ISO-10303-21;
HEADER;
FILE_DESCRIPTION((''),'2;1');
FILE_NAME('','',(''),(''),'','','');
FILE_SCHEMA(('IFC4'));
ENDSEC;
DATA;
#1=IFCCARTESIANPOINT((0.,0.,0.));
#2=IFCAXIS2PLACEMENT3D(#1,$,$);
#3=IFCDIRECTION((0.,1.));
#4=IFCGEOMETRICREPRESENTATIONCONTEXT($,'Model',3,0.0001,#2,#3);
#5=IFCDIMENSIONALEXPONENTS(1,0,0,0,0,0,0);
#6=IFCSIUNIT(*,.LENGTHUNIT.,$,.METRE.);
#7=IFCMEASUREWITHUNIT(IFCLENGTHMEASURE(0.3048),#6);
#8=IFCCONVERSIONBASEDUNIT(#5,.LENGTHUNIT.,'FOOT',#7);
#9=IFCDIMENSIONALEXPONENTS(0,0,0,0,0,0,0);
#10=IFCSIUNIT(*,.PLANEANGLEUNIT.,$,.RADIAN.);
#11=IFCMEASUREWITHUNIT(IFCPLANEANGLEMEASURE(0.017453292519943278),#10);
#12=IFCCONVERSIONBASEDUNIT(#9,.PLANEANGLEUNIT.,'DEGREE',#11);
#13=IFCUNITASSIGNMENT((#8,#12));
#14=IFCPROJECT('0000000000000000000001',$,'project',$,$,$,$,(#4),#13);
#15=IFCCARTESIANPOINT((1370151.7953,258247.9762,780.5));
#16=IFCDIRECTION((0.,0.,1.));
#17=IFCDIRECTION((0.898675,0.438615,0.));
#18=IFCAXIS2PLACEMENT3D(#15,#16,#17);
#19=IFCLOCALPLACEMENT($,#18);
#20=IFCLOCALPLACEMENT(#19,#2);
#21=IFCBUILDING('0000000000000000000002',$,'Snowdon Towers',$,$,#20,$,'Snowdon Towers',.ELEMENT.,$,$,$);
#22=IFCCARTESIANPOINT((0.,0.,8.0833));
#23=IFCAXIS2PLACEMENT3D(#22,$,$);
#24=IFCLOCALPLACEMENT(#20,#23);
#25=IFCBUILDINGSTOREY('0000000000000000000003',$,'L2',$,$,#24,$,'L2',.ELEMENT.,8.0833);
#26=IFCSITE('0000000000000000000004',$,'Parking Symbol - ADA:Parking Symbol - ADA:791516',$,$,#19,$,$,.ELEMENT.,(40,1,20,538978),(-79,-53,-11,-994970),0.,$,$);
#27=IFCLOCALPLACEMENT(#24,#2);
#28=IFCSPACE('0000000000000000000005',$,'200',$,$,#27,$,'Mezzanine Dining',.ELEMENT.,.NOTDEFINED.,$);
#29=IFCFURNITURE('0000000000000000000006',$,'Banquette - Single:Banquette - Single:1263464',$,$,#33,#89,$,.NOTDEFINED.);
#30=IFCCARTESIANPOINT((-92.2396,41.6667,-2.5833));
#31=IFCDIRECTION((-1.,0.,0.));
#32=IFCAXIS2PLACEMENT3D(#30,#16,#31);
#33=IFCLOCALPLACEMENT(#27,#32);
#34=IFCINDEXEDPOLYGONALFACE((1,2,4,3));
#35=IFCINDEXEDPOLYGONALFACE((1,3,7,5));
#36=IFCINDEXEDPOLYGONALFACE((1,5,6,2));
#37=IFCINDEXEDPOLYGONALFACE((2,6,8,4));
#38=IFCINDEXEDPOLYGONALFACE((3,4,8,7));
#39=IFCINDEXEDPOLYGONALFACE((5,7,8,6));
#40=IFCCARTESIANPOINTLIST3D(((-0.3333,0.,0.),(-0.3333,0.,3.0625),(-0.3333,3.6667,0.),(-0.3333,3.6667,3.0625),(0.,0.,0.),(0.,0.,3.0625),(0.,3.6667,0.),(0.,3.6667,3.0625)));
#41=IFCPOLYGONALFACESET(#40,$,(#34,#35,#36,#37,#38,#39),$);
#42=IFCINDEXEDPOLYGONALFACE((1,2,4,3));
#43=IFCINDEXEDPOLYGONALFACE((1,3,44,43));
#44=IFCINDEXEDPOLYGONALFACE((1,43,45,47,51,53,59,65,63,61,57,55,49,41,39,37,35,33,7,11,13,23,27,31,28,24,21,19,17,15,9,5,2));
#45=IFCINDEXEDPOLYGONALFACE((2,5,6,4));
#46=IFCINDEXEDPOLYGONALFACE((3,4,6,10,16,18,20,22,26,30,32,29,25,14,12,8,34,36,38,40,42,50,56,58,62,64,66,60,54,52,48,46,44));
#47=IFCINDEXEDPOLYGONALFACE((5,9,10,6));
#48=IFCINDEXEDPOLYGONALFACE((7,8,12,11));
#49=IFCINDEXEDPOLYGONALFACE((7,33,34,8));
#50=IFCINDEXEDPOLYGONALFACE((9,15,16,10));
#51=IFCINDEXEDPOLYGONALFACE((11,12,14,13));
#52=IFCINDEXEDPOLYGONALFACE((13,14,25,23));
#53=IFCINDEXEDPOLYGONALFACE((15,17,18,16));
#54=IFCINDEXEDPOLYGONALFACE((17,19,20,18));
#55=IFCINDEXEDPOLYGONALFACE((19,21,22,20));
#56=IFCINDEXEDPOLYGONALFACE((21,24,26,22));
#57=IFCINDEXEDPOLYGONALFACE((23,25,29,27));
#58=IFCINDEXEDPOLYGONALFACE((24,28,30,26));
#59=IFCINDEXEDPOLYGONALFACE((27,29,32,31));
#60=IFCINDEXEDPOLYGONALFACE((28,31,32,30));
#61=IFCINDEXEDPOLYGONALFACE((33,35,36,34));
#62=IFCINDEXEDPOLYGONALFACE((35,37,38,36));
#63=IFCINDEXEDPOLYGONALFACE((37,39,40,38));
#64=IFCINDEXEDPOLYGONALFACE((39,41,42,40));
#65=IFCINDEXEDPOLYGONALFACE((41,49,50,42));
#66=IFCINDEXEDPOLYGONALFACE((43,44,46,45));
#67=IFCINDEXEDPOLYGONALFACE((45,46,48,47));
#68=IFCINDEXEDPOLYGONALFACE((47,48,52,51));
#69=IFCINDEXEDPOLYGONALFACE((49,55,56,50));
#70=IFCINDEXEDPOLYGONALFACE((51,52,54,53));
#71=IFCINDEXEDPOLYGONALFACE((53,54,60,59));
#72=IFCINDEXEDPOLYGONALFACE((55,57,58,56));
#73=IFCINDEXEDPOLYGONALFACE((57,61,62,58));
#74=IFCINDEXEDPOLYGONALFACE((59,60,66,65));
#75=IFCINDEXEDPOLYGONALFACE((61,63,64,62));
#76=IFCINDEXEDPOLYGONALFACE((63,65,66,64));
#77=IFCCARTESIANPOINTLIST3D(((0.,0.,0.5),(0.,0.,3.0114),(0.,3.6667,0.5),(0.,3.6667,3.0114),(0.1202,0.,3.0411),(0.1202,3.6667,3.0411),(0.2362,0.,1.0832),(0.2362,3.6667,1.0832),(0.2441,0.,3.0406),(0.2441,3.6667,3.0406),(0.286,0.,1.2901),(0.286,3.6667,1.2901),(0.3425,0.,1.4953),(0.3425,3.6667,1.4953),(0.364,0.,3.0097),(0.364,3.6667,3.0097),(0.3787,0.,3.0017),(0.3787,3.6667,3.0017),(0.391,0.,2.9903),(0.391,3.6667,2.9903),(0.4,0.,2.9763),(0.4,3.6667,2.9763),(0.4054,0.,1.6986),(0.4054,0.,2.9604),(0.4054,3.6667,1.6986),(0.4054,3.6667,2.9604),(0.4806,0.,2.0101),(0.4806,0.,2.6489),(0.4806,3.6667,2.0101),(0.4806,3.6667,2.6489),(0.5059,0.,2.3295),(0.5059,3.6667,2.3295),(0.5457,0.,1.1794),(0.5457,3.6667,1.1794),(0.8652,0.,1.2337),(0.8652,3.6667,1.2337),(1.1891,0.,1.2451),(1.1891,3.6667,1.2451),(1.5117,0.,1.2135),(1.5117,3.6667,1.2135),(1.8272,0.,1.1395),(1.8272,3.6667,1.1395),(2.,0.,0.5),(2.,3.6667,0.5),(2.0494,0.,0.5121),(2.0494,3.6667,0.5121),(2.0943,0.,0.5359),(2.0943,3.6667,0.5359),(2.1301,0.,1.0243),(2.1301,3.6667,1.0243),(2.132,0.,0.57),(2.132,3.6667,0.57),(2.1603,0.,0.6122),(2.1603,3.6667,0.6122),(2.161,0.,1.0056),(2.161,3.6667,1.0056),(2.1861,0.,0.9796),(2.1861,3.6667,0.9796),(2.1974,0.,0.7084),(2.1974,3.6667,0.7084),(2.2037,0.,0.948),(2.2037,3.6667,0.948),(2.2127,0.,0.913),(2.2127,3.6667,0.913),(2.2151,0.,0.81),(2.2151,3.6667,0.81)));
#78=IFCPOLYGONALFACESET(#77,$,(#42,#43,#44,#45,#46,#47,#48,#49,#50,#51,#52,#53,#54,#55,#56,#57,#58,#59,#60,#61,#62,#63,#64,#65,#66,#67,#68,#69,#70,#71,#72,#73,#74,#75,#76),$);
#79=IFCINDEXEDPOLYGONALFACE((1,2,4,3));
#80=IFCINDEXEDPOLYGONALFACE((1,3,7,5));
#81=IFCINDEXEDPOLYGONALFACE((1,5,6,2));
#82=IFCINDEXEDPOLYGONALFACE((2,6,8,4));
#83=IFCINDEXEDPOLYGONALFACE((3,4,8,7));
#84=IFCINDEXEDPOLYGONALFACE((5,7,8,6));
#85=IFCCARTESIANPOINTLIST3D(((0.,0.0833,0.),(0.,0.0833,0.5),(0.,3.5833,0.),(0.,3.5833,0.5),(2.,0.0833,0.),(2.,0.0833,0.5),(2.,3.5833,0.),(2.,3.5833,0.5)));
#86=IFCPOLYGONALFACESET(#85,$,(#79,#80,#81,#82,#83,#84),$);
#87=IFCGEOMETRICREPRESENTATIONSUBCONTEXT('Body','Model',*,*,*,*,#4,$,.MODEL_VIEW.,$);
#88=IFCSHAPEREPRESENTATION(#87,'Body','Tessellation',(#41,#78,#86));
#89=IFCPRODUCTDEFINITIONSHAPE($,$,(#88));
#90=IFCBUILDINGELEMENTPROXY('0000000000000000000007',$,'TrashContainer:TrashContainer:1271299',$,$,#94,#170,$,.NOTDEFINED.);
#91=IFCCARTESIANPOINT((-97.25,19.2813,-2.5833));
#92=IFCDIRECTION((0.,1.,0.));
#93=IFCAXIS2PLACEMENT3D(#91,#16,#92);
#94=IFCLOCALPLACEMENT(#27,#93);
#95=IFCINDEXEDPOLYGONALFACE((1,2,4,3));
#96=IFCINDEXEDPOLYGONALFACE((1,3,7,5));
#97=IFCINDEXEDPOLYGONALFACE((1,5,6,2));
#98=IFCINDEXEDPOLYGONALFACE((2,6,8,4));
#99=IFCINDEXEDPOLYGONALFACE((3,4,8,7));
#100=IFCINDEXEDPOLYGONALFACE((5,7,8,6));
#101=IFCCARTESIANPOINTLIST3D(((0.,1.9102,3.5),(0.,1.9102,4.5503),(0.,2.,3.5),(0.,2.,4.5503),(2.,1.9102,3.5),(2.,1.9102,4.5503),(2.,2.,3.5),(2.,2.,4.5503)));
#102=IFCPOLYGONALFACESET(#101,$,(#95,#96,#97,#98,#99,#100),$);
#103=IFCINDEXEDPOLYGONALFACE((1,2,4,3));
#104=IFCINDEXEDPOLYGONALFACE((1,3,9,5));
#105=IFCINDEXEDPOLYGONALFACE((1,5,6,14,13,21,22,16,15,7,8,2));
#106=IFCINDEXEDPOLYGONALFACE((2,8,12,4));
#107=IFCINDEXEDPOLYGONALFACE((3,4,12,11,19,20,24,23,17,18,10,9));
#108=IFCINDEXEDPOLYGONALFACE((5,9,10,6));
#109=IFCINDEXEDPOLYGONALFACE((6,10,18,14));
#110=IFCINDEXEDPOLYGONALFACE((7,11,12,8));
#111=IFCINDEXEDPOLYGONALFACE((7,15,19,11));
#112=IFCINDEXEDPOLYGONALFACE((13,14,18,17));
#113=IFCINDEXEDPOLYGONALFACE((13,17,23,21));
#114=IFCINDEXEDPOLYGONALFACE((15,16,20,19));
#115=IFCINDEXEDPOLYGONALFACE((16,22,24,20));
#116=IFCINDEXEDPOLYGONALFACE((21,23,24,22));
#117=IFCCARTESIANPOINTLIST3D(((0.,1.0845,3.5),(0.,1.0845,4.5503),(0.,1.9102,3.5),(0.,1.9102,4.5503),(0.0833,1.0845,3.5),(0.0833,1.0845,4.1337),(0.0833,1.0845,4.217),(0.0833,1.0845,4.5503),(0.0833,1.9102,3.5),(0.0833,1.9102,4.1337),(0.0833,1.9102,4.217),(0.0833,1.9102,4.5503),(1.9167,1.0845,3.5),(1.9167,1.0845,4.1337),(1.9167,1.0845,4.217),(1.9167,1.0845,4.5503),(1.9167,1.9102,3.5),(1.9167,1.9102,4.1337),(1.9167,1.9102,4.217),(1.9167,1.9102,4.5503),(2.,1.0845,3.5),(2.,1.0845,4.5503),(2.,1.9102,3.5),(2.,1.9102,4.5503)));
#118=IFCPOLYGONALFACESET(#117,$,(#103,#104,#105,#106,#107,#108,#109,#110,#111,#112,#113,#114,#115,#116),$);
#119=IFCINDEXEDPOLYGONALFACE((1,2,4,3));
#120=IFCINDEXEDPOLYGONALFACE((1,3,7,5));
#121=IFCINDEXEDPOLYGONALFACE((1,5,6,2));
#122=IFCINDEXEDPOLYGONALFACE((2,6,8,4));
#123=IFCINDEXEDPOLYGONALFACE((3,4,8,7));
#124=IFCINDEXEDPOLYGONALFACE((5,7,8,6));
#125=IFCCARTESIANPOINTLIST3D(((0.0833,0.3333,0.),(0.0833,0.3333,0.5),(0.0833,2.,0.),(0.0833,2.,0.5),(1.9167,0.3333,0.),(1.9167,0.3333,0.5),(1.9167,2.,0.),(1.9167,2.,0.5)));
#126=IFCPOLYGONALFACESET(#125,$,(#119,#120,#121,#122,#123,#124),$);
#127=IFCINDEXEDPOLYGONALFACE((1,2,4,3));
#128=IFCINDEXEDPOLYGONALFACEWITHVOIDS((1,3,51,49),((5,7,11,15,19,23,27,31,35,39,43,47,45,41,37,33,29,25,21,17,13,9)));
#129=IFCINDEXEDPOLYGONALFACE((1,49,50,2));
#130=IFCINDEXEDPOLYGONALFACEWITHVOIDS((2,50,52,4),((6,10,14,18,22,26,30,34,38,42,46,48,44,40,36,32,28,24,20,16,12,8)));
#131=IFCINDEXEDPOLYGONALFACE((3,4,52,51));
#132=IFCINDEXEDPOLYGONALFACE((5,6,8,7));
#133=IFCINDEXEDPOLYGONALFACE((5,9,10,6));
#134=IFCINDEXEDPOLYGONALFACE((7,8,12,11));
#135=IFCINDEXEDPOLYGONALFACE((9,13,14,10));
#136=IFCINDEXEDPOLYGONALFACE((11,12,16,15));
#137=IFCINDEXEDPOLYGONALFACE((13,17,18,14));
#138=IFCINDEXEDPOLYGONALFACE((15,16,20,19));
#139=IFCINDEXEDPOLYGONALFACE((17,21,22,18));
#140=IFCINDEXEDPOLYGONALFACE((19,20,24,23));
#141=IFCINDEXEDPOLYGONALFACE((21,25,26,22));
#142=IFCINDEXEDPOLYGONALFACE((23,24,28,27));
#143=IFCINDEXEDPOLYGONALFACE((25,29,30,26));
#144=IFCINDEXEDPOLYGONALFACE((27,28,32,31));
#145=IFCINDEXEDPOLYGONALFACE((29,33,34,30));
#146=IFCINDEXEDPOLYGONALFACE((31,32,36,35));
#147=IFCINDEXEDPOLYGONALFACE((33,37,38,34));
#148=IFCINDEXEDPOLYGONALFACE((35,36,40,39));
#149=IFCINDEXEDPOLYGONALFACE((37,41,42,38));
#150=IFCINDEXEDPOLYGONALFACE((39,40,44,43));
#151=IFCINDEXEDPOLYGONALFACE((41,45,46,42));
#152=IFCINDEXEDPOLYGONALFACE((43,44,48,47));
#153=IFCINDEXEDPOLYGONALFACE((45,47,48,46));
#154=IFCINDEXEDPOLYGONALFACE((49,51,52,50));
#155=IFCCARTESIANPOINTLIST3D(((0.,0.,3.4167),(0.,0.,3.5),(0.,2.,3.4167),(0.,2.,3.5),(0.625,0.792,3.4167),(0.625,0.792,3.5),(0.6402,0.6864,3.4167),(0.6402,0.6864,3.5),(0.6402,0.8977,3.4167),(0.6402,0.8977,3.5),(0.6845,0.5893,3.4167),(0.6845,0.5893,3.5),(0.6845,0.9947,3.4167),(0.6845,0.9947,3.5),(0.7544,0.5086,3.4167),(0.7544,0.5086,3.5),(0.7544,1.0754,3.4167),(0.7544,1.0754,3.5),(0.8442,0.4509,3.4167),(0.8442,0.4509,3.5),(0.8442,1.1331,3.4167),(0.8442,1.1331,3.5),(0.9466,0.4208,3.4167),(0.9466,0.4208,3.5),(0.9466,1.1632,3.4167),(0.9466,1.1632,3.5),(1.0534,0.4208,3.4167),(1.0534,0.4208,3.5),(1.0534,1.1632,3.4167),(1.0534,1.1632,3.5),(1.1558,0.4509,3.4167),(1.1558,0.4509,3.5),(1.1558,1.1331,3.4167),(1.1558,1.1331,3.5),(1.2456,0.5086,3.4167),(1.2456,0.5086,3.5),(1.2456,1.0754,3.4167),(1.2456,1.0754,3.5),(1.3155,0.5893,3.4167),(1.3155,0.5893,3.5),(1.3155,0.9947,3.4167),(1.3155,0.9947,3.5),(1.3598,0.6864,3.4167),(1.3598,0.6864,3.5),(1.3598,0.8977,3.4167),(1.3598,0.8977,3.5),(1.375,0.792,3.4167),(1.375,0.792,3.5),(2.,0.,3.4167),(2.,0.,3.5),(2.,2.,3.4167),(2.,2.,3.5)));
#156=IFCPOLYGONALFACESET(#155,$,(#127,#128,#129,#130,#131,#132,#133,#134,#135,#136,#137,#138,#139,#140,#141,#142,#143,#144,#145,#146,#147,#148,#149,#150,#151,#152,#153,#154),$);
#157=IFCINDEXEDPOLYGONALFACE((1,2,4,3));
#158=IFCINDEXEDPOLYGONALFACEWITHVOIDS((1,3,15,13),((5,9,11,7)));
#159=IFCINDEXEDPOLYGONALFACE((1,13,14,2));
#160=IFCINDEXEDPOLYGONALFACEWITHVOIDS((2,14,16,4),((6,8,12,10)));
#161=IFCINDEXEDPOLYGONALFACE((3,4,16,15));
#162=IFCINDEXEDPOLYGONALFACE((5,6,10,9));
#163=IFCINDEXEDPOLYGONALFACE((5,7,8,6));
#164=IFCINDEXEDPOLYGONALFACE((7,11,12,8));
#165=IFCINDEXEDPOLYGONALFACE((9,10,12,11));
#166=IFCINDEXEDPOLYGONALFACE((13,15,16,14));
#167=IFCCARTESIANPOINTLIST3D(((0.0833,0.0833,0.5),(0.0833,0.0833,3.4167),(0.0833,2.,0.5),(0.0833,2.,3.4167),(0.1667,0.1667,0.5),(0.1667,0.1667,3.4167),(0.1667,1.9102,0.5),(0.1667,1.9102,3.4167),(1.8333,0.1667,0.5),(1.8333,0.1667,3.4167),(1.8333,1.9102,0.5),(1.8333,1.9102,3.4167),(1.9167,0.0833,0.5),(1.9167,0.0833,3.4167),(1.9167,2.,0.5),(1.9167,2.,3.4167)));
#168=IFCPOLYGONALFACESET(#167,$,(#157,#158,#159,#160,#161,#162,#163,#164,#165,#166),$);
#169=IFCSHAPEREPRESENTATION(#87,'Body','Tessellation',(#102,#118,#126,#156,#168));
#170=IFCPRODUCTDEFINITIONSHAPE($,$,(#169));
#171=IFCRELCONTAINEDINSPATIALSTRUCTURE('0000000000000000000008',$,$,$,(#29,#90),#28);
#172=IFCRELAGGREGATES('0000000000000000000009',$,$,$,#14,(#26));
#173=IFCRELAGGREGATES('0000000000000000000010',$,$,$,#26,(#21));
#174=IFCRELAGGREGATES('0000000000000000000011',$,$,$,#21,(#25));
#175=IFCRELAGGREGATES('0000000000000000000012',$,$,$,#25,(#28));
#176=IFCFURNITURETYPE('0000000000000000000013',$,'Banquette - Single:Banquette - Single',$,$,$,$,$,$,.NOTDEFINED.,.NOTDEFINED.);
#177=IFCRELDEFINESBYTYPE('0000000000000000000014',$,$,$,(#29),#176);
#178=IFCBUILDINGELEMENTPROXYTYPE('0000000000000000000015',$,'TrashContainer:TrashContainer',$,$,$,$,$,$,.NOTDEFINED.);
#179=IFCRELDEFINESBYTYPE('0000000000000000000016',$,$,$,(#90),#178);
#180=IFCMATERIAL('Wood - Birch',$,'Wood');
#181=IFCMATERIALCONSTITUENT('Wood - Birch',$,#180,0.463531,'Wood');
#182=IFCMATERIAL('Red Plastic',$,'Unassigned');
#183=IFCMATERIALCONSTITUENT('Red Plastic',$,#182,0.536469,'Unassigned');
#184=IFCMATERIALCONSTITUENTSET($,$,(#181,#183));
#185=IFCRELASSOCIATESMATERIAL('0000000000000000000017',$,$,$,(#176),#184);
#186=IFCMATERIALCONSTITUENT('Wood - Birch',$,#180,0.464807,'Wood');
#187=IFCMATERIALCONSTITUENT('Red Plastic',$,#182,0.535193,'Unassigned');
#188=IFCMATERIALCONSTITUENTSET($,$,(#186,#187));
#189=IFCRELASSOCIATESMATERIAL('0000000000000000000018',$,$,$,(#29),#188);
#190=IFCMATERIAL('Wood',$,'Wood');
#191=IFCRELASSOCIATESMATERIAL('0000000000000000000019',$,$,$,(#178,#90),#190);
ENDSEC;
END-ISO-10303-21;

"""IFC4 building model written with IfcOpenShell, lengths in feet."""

from ifc_helpers import new_model, entity, si_unit, converted_unit, direction, frame, origin, place, context, subcontext, project, spatial, line, arc, indexed_curve, outline, extrude, source, transform, mapped, material, constituent, constituent_set, type_object, type_shapes, element, save


model = new_model("IFC4")

# Units and contexts
model_context = context("Model", 3, precision=0.0001, world=origin(), true_north=direction((0.0, 1.0)))
body_context = subcontext(model_context, "Body", "Model", "MODEL_VIEW")
ifc_project = project(units=[converted_unit("LENGTHUNIT", "FOOT", entity("IfcLengthMeasure", 0.3048), si_unit("LENGTHUNIT", "METRE"), dimensions=[1, 0, 0, 0, 0, 0, 0]), converted_unit("PLANEANGLEUNIT", "DEGREE", entity("IfcPlaneAngleMeasure", 0.017453292519943278), si_unit("PLANEANGLEUNIT", "RADIAN"), dimensions=[0, 0, 0, 0, 0, 0, 0])], contexts=[model_context])

# Site, building, storey
site_placement = place(None, frame((1370151.7953, 258247.9762, 780.5), z_axis=(0.0, 0.0, 1.0), x_axis=(0.898675, 0.438615, 0.0)))
site = spatial("IfcSite", under=ifc_project, at=site_placement, Name="Parking Symbol - ADA:Parking Symbol - ADA:791516", CompositionType="ELEMENT", RefLatitude=(40, 1, 20, 538978), RefLongitude=(-79, -53, -11, -994970), RefElevation=0.0)
building_placement = place(site_placement, origin())
building = spatial("IfcBuilding", under=site, at=building_placement, Name="Snowdon Towers", LongName="Snowdon Towers", CompositionType="ELEMENT")
storey_placement = place(building_placement, frame((0.0, 0.0, 8.0833)))
storey = spatial("IfcBuildingStorey", under=building, at=storey_placement, Name="L2", LongName="L2", CompositionType="ELEMENT", Elevation=8.0833)

# Shared definitions
space_1_placement = place(storey_placement, origin())
space_1 = spatial("IfcSpace", under=storey, at=space_1_placement, Name="200", LongName="Mezzanine Dining", CompositionType="ELEMENT", PredefinedType="NOTDEFINED")

# Furniture
ifc_material_1 = material(Name="Wood - Birch", Category="Wood")
ifc_material_2 = material(Name="Red Plastic", Category="Unassigned")
ifc_constituent_1 = constituent(ifc_material_1, Name="Wood - Birch", Category="Wood", fraction=0.464807)
ifc_constituent_2 = constituent(ifc_material_2, Name="Red Plastic", Category="Unassigned", fraction=0.535193)
ifc_constituent_set_1 = constituent_set(constituents=[ifc_constituent_1, ifc_constituent_2])
ifc_constituent_3 = constituent(ifc_material_1, Name="Wood - Birch", Category="Wood", fraction=0.463531)
ifc_constituent_4 = constituent(ifc_material_2, Name="Red Plastic", Category="Unassigned", fraction=0.536469)
ifc_constituent_set_2 = constituent_set(constituents=[ifc_constituent_3, ifc_constituent_4])
furniture_type_1 = type_object("IfcFurnitureType", Name="Banquette - Single:Banquette - Single", AssemblyPlace="NOTDEFINED", PredefinedType="NOTDEFINED", material=ifc_constituent_set_2)
shared_shape_1 = source(origin(), body_context, "Body", "SweptSolid", [
    extrude(outline(indexed_curve([(-0.1667, -1.8333), (0.1667, -1.8333), (0.1667, 1.8333), (-0.1667, 1.8333), (-0.1667, -1.8333)], self_intersect=False)), frame((-0.1667, 1.8333, 0.0)), (0.0, 0.0, 1.0), 3.0625),
    extrude(outline(indexed_curve([(1.1689, 0.9191), (1.1029, 0.9954), (1.0086, 1.0313), (-0.9914, 1.0313), (-0.9914, -1.4801), (-0.8092, -1.5134), (-0.6274, -1.4784), (-0.6004, -1.459), (-0.586, -1.4291), (-0.4855, -0.7982), (-0.586, -0.1673), (-0.678, 0.1384), (-0.7552, 0.4481), (0.1977, 0.2862), (1.1387, 0.507), (1.1947, 0.5517), (1.2213, 0.6183), (1.2173, 0.7725)], segments=[arc(1, 2, 3), line(3, 4, 5), arc(5, 6, 7), arc(7, 8, 9), arc(9, 10, 11), arc(11, 12, 13), arc(13, 14, 15), arc(15, 16, 17), arc(17, 18, 1)], self_intersect=False)), frame((0.9914, 0.0, 1.5313), z_axis=(0.0, 1.0, 0.0), x_axis=(1.0, 0.0, 0.0)), (0.0, 0.0, 1.0), 3.6667),
    extrude(outline(indexed_curve([(-1.75, -1.0), (1.75, -1.0), (1.75, 1.0), (-1.75, 1.0), (-1.75, -1.0)], self_intersect=False)), frame((1.0, 1.8333, 0.0), z_axis=(0.0, 0.0, 1.0), x_axis=(0.0, 1.0, 0.0)), (0.0, 0.0, 1.0), 0.5),
])
type_shapes(furniture_type_1, [shared_shape_1])
furniture_1_placement = place(space_1_placement, frame((-92.2396, 41.6667, -2.5833), z_axis=(0.0, 0.0, 1.0), x_axis=(-1.0, 0.0, 0.0)))
element("IfcFurniture", 1, at=furniture_1_placement, inside=space_1, type_object=furniture_type_1, material=ifc_constituent_set_1, Name="Banquette - Single:Banquette - Single:1263464", PredefinedType="NOTDEFINED", context=body_context, shape_type="MappedRepresentation", body=[
    mapped(shared_shape_1, transform((0.0, 0.0, 0.0), scale=1.0)),
])

# Building element proxy
ifc_material_3 = material(Name="Wood", Category="Wood")
building_element_proxy_type_1 = type_object("IfcBuildingElementProxyType", Name="TrashContainer:TrashContainer", PredefinedType="NOTDEFINED", material=ifc_material_3)
shared_shape_2 = source(origin(), body_context, "Body", "SweptSolid", [
    extrude(outline(indexed_curve([(-1.0, -0.0449), (1.0, -0.0449), (1.0, 0.0449), (-1.0, 0.0449), (-1.0, -0.0449)], self_intersect=False)), frame((1.0, 1.9551, 3.5), z_axis=(0.0, 0.0, 1.0), x_axis=(-1.0, 0.0, 0.0)), (0.0, 0.0, 1.0), 1.0503),
    extrude(outline(indexed_curve([(-1.0, -0.4751), (-0.9167, -0.4751), (-0.9167, -0.1418), (0.9167, -0.1418), (0.9167, -0.4751), (1.0, -0.4751), (1.0, 0.5752), (0.9167, 0.5752), (0.9167, -0.0584), (-0.9167, -0.0584), (-0.9167, 0.5752), (-1.0, 0.5752), (-1.0, -0.4751)], self_intersect=False)), frame((1.0, 1.0845, 4.0752), z_axis=(0.0, 1.0, 0.0), x_axis=(1.0, 0.0, 0.0)), (0.0, 0.0, 1.0), 0.8256),
    extrude(outline(indexed_curve([(-0.9167, -0.8333), (0.9167, -0.8333), (0.9167, 0.8333), (-0.9167, 0.8333), (-0.9167, -0.8333)], self_intersect=False)), frame((1.0, 1.1667, 0.0), z_axis=(0.0, 0.0, 1.0), x_axis=(-1.0, 0.0, 0.0)), (0.0, 0.0, 1.0), 0.5),
    extrude(outline(indexed_curve([(-1.0, -1.0), (1.0, -1.0), (1.0, 1.0), (-1.0, 1.0), (-1.0, -1.0)], self_intersect=False), holes=[indexed_curve([(0.208, -0.375), (-0.167, 0.0), (0.208, 0.375), (0.583, 0.0)], segments=[arc(1, 2, 3), arc(3, 4, 1)], self_intersect=False)]), frame((1.0, 1.0, 3.4167), z_axis=(0.0, 0.0, 1.0), x_axis=(0.0, -1.0, 0.0)), (0.0, 0.0, 1.0), 0.0833),
    extrude(outline(indexed_curve([(-0.9583, -0.9167), (0.9583, -0.9167), (0.9583, 0.9167), (-0.9583, 0.9167), (-0.9583, -0.9167)], self_intersect=False), holes=[indexed_curve([(-0.8685, -0.8333), (-0.8685, 0.8333), (0.875, 0.8333), (0.875, -0.8333), (-0.8685, -0.8333)], self_intersect=False)]), frame((1.0, 1.0417, 0.5), z_axis=(0.0, 0.0, 1.0), x_axis=(0.0, -1.0, 0.0)), (0.0, 0.0, 1.0), 2.9167),
])
type_shapes(building_element_proxy_type_1, [shared_shape_2])
proxy_1_placement = place(space_1_placement, frame((-97.25, 19.2813, -2.5833), z_axis=(0.0, 0.0, 1.0), x_axis=(0.0, 1.0, 0.0)))
element("IfcBuildingElementProxy", 2, at=proxy_1_placement, inside=space_1, type_object=building_element_proxy_type_1, material=ifc_material_3, Name="TrashContainer:TrashContainer:1271299", PredefinedType="NOTDEFINED", context=body_context, shape_type="MappedRepresentation", body=[
    mapped(shared_shape_2, transform((0.0, 0.0, 0.0), scale=1.0)),
])

save(model, "model.ifc")
